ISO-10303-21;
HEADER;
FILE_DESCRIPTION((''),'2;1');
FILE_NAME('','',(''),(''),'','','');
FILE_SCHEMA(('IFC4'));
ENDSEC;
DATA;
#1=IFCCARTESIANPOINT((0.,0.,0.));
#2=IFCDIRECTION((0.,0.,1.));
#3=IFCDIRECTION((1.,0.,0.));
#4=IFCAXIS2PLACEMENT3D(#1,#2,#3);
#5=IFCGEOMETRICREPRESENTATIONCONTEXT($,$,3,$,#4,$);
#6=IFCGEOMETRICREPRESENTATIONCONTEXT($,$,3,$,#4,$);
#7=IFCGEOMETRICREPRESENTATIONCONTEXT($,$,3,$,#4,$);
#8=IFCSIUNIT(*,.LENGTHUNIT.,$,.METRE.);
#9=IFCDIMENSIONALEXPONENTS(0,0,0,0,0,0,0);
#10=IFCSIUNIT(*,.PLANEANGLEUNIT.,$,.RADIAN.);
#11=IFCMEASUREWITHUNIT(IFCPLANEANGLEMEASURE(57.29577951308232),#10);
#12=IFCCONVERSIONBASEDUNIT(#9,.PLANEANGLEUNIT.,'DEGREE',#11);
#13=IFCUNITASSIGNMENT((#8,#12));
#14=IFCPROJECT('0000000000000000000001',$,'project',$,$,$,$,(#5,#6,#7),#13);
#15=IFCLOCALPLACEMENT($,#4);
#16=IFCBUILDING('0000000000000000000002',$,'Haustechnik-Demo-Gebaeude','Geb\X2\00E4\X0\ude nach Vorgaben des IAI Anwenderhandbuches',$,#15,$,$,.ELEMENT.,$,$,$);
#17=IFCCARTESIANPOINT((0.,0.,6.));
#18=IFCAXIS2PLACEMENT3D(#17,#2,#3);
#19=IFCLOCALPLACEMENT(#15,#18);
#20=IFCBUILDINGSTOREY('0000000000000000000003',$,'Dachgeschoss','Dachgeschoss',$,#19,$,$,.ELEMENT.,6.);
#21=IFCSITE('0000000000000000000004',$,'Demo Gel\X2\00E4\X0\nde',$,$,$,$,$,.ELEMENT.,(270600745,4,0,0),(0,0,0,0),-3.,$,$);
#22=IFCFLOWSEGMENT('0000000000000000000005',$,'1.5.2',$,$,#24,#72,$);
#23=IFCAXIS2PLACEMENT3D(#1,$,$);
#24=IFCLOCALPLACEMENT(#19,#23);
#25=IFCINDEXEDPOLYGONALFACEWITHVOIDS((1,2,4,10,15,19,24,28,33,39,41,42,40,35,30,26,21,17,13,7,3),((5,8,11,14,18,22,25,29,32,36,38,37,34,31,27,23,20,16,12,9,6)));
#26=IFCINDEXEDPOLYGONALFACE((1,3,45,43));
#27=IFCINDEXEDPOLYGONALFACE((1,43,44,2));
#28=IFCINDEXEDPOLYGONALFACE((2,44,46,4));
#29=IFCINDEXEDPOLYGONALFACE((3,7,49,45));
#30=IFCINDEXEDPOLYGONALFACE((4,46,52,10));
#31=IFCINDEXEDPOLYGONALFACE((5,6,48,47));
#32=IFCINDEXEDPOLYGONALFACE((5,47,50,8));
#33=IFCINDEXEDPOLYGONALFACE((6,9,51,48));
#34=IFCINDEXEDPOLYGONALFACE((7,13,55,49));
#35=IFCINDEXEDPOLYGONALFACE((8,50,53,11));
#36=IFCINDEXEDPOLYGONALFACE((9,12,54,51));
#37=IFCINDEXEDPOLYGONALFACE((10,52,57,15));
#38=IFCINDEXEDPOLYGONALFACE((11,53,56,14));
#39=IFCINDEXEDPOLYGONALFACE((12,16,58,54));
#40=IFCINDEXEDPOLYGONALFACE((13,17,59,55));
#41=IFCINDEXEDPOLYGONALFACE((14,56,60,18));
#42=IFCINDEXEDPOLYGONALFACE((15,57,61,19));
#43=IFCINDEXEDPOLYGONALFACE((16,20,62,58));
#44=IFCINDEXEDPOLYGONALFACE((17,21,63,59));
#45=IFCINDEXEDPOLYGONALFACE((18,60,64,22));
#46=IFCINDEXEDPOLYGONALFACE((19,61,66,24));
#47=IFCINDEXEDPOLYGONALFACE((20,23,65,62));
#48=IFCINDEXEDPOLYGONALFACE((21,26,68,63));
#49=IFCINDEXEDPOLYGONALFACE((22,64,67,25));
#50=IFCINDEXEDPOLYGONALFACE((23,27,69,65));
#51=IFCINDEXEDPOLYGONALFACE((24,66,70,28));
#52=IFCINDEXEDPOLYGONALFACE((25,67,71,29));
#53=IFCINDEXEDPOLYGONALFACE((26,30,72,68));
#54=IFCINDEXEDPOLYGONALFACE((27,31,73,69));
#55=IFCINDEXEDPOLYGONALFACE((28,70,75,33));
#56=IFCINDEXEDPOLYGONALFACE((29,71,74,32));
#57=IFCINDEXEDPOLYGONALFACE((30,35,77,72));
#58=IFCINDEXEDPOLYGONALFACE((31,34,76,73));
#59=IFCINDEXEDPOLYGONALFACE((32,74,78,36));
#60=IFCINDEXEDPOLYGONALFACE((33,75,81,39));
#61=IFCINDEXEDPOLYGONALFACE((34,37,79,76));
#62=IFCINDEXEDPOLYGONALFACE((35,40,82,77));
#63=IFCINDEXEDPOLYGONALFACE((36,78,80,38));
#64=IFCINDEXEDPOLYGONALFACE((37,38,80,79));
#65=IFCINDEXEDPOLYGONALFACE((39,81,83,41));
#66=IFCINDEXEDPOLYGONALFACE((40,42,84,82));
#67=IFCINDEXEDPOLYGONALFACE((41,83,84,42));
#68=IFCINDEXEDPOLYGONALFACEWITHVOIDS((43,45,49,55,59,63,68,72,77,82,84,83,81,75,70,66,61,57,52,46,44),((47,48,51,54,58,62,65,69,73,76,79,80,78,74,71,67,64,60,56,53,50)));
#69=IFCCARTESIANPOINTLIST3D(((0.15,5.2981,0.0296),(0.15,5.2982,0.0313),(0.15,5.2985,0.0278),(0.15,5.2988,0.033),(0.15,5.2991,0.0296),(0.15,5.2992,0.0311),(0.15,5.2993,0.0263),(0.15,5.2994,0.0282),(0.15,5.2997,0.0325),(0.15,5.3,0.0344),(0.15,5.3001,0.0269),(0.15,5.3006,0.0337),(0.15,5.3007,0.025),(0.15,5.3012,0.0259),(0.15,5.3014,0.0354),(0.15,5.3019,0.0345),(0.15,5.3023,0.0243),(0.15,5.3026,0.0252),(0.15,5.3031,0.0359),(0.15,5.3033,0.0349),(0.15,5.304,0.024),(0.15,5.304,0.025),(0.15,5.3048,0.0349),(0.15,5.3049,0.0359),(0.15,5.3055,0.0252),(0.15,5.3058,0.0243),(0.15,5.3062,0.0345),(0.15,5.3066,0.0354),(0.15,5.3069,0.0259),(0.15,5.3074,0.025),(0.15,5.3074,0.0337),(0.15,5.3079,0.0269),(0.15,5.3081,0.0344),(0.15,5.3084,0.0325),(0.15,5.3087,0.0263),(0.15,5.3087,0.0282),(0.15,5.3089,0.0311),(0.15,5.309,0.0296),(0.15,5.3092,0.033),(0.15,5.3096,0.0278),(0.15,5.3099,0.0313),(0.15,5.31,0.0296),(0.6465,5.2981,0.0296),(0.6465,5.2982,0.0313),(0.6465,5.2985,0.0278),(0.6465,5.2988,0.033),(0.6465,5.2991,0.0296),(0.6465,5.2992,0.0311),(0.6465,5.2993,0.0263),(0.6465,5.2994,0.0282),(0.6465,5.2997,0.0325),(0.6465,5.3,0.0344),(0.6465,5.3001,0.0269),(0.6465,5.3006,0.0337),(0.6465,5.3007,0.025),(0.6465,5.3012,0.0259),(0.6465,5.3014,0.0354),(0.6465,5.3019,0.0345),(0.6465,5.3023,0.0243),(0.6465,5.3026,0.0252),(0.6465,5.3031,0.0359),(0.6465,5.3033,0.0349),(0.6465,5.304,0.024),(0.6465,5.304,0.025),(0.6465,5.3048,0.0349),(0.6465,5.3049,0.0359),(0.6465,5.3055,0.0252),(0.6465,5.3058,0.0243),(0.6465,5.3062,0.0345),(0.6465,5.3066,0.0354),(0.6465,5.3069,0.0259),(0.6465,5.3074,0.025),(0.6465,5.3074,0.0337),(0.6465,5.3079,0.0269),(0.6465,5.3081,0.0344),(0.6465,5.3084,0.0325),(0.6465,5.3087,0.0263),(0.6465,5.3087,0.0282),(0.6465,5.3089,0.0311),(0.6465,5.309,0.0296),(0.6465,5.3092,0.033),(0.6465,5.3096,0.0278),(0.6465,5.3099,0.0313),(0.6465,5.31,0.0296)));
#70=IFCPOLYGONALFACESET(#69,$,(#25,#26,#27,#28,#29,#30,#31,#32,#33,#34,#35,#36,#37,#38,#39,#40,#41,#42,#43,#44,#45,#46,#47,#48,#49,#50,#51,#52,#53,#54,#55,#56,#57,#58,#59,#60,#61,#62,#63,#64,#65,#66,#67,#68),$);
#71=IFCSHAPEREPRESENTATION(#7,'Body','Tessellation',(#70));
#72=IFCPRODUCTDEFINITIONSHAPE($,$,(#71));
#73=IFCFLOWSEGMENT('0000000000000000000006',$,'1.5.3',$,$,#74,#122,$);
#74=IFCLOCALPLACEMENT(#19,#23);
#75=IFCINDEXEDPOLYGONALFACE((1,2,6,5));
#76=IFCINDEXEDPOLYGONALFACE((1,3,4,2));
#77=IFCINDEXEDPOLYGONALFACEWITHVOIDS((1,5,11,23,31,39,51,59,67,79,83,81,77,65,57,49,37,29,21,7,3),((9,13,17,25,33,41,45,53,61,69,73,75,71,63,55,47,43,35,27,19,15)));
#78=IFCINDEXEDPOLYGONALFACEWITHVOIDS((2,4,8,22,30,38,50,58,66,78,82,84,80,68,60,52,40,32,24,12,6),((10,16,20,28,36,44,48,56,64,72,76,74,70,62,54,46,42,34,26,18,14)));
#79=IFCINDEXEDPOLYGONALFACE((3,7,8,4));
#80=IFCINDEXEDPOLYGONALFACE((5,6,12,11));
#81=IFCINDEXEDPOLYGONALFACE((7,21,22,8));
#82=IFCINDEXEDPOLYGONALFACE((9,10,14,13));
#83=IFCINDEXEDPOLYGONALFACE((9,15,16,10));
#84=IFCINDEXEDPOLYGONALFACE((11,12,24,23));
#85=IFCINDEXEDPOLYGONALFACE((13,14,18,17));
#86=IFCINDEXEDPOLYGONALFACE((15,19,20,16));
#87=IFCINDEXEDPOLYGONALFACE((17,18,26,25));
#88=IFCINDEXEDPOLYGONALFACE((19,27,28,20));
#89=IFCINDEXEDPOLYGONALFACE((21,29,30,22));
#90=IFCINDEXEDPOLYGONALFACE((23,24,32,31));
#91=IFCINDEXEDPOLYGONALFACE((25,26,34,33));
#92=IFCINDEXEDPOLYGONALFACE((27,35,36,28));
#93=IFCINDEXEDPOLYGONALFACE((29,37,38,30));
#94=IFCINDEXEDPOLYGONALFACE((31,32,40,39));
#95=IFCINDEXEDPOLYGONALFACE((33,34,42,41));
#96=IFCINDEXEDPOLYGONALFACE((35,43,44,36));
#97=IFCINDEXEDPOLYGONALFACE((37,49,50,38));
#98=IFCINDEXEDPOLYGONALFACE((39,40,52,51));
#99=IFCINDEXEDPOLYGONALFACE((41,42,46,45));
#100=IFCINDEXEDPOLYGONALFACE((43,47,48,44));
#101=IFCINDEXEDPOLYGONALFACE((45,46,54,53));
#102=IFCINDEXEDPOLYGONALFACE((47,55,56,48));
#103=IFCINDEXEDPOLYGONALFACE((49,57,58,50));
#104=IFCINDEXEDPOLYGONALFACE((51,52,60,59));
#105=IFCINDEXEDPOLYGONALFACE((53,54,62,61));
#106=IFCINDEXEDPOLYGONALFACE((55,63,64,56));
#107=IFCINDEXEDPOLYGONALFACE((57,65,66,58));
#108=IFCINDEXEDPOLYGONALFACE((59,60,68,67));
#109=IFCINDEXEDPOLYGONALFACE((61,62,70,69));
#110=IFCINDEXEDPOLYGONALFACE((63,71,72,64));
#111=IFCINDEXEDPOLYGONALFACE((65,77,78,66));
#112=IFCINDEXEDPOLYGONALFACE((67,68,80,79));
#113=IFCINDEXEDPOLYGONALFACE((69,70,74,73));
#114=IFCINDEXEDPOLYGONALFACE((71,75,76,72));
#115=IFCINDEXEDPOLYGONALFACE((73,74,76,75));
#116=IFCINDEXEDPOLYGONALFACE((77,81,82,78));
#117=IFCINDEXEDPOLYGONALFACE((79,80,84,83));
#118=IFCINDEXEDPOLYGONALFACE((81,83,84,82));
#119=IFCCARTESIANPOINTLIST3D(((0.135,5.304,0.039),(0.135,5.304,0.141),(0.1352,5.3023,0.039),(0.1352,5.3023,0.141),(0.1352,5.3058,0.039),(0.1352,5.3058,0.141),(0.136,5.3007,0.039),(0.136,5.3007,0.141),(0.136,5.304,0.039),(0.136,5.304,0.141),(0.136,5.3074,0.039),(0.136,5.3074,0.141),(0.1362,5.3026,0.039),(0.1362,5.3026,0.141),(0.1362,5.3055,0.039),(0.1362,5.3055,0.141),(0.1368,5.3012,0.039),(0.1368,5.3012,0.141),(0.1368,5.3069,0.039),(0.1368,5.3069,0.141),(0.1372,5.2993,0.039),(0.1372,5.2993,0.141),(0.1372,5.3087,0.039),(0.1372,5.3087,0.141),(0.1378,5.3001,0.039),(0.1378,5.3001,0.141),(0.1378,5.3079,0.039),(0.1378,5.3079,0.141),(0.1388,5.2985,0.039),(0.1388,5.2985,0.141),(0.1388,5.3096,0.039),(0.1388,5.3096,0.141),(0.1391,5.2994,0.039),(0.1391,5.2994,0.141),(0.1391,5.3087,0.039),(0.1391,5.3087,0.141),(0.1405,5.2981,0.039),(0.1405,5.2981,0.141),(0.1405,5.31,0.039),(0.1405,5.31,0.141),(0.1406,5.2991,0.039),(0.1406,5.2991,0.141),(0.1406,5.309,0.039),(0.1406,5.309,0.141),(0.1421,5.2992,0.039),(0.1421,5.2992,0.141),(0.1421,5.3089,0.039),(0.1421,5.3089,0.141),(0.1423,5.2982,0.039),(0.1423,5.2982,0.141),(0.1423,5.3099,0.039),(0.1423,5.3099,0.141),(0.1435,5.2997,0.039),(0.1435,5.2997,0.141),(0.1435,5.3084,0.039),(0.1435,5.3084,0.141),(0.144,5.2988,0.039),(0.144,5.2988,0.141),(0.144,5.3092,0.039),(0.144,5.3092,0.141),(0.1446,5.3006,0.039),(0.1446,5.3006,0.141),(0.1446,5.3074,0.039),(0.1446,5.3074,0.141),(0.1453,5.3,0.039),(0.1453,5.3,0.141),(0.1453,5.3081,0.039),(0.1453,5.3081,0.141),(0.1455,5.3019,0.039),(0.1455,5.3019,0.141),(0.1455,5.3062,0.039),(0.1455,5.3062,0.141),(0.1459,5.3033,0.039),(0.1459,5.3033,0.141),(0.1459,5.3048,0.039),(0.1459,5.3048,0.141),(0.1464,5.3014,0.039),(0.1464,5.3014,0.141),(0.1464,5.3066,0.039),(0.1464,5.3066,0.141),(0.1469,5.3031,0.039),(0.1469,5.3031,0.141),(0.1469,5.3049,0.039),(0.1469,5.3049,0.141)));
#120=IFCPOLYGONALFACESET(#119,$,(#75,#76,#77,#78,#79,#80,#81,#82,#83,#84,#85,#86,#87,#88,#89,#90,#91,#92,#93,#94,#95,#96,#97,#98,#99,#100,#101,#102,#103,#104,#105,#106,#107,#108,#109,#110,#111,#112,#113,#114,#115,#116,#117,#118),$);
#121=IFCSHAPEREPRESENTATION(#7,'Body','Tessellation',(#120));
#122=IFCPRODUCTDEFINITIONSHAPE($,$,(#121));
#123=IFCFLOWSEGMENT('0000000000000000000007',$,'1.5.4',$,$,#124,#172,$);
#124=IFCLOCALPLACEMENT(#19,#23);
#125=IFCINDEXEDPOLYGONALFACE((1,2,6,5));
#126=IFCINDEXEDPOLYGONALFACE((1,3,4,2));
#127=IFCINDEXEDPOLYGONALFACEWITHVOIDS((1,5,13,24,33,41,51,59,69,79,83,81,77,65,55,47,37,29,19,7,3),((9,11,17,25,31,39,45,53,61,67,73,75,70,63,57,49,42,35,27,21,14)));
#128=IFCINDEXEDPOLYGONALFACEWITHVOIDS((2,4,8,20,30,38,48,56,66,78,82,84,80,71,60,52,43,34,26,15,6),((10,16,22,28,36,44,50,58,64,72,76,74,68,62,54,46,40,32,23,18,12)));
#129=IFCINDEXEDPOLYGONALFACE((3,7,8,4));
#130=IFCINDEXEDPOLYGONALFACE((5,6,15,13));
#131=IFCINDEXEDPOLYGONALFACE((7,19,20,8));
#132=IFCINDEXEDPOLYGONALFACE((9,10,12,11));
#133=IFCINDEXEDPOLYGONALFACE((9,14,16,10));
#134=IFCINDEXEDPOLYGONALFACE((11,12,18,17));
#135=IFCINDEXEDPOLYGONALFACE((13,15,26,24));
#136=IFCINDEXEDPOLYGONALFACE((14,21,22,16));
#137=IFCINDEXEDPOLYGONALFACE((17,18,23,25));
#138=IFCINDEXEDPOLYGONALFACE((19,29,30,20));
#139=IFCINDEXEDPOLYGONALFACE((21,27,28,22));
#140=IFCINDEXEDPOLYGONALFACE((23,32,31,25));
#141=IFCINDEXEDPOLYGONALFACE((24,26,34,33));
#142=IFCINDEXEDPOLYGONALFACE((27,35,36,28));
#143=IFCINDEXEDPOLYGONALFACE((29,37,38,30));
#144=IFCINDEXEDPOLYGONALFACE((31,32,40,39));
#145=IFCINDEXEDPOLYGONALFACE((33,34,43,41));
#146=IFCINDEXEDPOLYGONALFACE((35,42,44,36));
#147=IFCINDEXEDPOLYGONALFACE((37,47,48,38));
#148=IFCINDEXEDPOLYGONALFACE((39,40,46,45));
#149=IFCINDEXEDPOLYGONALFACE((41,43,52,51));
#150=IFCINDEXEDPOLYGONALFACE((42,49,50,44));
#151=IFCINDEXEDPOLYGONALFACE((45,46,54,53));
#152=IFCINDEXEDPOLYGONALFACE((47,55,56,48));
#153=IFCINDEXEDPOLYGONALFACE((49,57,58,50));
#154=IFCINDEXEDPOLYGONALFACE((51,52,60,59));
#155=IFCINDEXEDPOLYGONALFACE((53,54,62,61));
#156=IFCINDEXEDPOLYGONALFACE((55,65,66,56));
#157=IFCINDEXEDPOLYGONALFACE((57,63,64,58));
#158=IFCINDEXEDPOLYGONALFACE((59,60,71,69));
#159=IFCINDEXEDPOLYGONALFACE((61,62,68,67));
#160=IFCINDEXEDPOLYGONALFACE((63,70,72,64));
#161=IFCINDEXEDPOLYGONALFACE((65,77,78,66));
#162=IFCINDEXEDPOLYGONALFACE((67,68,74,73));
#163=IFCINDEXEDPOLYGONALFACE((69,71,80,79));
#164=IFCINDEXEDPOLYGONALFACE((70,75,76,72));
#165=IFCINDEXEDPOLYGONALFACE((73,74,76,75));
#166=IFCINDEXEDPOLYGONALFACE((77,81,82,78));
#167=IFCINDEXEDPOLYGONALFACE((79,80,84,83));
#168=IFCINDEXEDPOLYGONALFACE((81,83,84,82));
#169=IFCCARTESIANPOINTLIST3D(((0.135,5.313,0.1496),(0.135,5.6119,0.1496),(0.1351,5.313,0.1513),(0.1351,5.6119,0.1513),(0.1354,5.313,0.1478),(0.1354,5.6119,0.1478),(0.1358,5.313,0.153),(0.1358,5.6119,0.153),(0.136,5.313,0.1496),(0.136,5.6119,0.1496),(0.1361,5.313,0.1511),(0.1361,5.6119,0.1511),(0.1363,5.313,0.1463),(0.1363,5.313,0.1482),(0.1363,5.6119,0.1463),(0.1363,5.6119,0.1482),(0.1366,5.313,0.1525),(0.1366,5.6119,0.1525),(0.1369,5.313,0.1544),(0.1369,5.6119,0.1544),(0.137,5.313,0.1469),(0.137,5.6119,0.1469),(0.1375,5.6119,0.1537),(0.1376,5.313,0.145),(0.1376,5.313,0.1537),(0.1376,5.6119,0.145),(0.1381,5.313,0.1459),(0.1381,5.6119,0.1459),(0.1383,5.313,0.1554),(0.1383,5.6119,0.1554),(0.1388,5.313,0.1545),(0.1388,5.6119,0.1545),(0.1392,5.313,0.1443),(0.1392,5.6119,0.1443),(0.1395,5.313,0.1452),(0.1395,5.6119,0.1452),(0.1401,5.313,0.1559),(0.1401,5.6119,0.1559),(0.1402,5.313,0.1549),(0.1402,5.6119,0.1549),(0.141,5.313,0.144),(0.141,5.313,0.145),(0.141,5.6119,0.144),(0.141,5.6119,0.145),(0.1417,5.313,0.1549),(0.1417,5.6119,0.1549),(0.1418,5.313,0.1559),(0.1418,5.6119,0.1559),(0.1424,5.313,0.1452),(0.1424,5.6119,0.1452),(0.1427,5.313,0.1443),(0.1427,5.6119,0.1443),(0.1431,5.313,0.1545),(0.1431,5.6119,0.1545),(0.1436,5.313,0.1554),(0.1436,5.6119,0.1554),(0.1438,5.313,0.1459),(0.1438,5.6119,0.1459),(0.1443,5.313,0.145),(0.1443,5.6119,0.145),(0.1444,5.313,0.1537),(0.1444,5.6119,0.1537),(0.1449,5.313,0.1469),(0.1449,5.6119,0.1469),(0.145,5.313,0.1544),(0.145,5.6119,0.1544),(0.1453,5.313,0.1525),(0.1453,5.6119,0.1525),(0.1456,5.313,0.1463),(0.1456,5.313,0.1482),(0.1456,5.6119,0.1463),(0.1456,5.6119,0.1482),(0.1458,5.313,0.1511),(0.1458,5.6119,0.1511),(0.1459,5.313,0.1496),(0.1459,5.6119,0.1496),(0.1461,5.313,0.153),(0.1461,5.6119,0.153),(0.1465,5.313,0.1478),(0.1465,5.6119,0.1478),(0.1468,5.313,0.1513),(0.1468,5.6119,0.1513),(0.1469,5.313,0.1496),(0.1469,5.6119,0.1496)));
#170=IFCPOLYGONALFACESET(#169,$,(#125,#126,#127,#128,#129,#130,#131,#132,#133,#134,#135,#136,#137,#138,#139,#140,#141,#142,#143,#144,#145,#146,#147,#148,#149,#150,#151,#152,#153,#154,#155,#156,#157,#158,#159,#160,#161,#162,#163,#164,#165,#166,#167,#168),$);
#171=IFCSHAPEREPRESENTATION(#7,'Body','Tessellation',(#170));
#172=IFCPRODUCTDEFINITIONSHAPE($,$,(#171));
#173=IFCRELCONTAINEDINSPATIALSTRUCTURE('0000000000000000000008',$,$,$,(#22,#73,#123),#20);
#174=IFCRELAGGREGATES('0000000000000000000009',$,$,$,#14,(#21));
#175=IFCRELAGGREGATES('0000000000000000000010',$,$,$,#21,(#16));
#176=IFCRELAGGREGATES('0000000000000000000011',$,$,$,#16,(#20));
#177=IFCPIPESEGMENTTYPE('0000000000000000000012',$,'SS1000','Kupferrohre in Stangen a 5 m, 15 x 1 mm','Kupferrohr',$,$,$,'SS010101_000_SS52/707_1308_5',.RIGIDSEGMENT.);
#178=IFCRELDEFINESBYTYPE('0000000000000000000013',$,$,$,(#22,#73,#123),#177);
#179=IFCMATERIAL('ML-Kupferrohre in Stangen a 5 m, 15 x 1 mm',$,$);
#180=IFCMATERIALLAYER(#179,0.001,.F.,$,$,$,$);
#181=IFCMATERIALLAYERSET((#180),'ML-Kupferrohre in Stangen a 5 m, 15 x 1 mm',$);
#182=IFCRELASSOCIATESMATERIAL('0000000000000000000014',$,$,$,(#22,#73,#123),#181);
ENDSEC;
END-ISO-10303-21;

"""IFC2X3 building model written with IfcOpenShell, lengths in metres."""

from ifc_helpers import new_model, entity, si_unit, converted_unit, frame, origin_with_axes, origin_2d_with_axis, place, context, project, spatial, hollow_circle, extrude, material, layer, layer_set, layer_usage, type_object, element, save


model = new_model("IFC2X3")

# Units and contexts
context_of_model_1 = context(None, 3, world=origin_with_axes())
context_of_model_2 = context(None, 3, world=origin_with_axes())
context_of_model_3 = context(None, 3, world=origin_with_axes())
ifc_project = project(units=[si_unit("LENGTHUNIT", "METRE"), converted_unit("PLANEANGLEUNIT", "DEGREE", entity("IfcPlaneAngleMeasure", 57.29577951308232), si_unit("PLANEANGLEUNIT", "RADIAN"), dimensions=[0, 0, 0, 0, 0, 0, 0])], contexts=[context_of_model_1, context_of_model_2, context_of_model_3])

# Site, building, storey
site = spatial("IfcSite", under=ifc_project, Name="Demo Gelände", CompositionType="ELEMENT", RefLatitude=(270600745, 4, 0, 0), RefLongitude=(0, 0, 0, 0), RefElevation=-3.0)
building_placement = place(None, origin_with_axes())
building = spatial("IfcBuilding", under=site, at=building_placement, Name="Haustechnik-Demo-Gebaeude", Description="Gebäude nach Vorgaben des IAI Anwenderhandbuches", CompositionType="ELEMENT")
storey_placement = place(building_placement, frame((0.0, 0.0, 6.0), z_axis=(0.0, 0.0, 1.0), x_axis=(1.0, 0.0, 0.0)))
storey = spatial("IfcBuildingStorey", under=building, at=storey_placement, Name="Dachgeschoss", Description="Dachgeschoss", CompositionType="ELEMENT", Elevation=6.0)

# Flow segments
ifc_material = material(Name="ML-Kupferrohre in Stangen a 5 m, 15 x 1 mm")
ifc_layer = layer(ifc_material, 0.001, ventilated=False)
ifc_layer_set = layer_set([ifc_layer], Name="ML-Kupferrohre in Stangen a 5 m, 15 x 1 mm")
ifc_layer_usage = layer_usage(ifc_layer_set, "AXIS2", "POSITIVE", 0.0)
pipe_segment_type_1 = type_object("IfcPipeSegmentType", Name="SS1000", Description="Kupferrohre in Stangen a 5 m, 15 x 1 mm", ApplicableOccurrence="Kupferrohr", ElementType="SS010101_000_SS52/707_1308_5", PredefinedType="RIGIDSEGMENT")
flow_segment_1_placement = place(storey_placement, frame((0.6465, 5.304, 0.03), z_axis=(-1.0, 0.0, 0.0), x_axis=(0.0, 0.0, -1.0)))
element("IfcFlowSegment", 1, at=flow_segment_1_placement, inside=storey, type_object=pipe_segment_type_1, material=ifc_layer_usage, Name="1.5.2", context=context_of_model_3, shape_type="SweptSolid", body=[
    extrude(hollow_circle(Radius=0.006, WallThickness=0.001, at=origin_2d_with_axis()), origin_with_axes(), (0.0, 0.0, 1.0), 0.4966),
])
flow_segment_2_placement = place(storey_placement, frame((0.141, 5.304, 0.039), z_axis=(0.0, 0.0, 1.0), x_axis=(-1.0, 0.0, 0.0)))
element("IfcFlowSegment", 2, at=flow_segment_2_placement, inside=storey, type_object=pipe_segment_type_1, material=ifc_layer_usage, Name="1.5.3", context=context_of_model_3, shape_type="SweptSolid", body=[
    extrude(hollow_circle(Radius=0.006, WallThickness=0.001, at=origin_2d_with_axis()), origin_with_axes(), (0.0, 0.0, 1.0), 0.102),
])
flow_segment_3_placement = place(storey_placement, frame((0.141, 5.313, 0.15), z_axis=(-0.000002, 1.0, 0.0), x_axis=(0.0, 0.0, -1.0)))
element("IfcFlowSegment", 3, at=flow_segment_3_placement, inside=storey, type_object=pipe_segment_type_1, material=ifc_layer_usage, Name="1.5.4", context=context_of_model_3, shape_type="SweptSolid", body=[
    extrude(hollow_circle(Radius=0.006, WallThickness=0.001, at=origin_2d_with_axis()), origin_with_axes(), (0.0, 0.0, 1.0), 0.2988),
])

save(model, "model.ifc")
